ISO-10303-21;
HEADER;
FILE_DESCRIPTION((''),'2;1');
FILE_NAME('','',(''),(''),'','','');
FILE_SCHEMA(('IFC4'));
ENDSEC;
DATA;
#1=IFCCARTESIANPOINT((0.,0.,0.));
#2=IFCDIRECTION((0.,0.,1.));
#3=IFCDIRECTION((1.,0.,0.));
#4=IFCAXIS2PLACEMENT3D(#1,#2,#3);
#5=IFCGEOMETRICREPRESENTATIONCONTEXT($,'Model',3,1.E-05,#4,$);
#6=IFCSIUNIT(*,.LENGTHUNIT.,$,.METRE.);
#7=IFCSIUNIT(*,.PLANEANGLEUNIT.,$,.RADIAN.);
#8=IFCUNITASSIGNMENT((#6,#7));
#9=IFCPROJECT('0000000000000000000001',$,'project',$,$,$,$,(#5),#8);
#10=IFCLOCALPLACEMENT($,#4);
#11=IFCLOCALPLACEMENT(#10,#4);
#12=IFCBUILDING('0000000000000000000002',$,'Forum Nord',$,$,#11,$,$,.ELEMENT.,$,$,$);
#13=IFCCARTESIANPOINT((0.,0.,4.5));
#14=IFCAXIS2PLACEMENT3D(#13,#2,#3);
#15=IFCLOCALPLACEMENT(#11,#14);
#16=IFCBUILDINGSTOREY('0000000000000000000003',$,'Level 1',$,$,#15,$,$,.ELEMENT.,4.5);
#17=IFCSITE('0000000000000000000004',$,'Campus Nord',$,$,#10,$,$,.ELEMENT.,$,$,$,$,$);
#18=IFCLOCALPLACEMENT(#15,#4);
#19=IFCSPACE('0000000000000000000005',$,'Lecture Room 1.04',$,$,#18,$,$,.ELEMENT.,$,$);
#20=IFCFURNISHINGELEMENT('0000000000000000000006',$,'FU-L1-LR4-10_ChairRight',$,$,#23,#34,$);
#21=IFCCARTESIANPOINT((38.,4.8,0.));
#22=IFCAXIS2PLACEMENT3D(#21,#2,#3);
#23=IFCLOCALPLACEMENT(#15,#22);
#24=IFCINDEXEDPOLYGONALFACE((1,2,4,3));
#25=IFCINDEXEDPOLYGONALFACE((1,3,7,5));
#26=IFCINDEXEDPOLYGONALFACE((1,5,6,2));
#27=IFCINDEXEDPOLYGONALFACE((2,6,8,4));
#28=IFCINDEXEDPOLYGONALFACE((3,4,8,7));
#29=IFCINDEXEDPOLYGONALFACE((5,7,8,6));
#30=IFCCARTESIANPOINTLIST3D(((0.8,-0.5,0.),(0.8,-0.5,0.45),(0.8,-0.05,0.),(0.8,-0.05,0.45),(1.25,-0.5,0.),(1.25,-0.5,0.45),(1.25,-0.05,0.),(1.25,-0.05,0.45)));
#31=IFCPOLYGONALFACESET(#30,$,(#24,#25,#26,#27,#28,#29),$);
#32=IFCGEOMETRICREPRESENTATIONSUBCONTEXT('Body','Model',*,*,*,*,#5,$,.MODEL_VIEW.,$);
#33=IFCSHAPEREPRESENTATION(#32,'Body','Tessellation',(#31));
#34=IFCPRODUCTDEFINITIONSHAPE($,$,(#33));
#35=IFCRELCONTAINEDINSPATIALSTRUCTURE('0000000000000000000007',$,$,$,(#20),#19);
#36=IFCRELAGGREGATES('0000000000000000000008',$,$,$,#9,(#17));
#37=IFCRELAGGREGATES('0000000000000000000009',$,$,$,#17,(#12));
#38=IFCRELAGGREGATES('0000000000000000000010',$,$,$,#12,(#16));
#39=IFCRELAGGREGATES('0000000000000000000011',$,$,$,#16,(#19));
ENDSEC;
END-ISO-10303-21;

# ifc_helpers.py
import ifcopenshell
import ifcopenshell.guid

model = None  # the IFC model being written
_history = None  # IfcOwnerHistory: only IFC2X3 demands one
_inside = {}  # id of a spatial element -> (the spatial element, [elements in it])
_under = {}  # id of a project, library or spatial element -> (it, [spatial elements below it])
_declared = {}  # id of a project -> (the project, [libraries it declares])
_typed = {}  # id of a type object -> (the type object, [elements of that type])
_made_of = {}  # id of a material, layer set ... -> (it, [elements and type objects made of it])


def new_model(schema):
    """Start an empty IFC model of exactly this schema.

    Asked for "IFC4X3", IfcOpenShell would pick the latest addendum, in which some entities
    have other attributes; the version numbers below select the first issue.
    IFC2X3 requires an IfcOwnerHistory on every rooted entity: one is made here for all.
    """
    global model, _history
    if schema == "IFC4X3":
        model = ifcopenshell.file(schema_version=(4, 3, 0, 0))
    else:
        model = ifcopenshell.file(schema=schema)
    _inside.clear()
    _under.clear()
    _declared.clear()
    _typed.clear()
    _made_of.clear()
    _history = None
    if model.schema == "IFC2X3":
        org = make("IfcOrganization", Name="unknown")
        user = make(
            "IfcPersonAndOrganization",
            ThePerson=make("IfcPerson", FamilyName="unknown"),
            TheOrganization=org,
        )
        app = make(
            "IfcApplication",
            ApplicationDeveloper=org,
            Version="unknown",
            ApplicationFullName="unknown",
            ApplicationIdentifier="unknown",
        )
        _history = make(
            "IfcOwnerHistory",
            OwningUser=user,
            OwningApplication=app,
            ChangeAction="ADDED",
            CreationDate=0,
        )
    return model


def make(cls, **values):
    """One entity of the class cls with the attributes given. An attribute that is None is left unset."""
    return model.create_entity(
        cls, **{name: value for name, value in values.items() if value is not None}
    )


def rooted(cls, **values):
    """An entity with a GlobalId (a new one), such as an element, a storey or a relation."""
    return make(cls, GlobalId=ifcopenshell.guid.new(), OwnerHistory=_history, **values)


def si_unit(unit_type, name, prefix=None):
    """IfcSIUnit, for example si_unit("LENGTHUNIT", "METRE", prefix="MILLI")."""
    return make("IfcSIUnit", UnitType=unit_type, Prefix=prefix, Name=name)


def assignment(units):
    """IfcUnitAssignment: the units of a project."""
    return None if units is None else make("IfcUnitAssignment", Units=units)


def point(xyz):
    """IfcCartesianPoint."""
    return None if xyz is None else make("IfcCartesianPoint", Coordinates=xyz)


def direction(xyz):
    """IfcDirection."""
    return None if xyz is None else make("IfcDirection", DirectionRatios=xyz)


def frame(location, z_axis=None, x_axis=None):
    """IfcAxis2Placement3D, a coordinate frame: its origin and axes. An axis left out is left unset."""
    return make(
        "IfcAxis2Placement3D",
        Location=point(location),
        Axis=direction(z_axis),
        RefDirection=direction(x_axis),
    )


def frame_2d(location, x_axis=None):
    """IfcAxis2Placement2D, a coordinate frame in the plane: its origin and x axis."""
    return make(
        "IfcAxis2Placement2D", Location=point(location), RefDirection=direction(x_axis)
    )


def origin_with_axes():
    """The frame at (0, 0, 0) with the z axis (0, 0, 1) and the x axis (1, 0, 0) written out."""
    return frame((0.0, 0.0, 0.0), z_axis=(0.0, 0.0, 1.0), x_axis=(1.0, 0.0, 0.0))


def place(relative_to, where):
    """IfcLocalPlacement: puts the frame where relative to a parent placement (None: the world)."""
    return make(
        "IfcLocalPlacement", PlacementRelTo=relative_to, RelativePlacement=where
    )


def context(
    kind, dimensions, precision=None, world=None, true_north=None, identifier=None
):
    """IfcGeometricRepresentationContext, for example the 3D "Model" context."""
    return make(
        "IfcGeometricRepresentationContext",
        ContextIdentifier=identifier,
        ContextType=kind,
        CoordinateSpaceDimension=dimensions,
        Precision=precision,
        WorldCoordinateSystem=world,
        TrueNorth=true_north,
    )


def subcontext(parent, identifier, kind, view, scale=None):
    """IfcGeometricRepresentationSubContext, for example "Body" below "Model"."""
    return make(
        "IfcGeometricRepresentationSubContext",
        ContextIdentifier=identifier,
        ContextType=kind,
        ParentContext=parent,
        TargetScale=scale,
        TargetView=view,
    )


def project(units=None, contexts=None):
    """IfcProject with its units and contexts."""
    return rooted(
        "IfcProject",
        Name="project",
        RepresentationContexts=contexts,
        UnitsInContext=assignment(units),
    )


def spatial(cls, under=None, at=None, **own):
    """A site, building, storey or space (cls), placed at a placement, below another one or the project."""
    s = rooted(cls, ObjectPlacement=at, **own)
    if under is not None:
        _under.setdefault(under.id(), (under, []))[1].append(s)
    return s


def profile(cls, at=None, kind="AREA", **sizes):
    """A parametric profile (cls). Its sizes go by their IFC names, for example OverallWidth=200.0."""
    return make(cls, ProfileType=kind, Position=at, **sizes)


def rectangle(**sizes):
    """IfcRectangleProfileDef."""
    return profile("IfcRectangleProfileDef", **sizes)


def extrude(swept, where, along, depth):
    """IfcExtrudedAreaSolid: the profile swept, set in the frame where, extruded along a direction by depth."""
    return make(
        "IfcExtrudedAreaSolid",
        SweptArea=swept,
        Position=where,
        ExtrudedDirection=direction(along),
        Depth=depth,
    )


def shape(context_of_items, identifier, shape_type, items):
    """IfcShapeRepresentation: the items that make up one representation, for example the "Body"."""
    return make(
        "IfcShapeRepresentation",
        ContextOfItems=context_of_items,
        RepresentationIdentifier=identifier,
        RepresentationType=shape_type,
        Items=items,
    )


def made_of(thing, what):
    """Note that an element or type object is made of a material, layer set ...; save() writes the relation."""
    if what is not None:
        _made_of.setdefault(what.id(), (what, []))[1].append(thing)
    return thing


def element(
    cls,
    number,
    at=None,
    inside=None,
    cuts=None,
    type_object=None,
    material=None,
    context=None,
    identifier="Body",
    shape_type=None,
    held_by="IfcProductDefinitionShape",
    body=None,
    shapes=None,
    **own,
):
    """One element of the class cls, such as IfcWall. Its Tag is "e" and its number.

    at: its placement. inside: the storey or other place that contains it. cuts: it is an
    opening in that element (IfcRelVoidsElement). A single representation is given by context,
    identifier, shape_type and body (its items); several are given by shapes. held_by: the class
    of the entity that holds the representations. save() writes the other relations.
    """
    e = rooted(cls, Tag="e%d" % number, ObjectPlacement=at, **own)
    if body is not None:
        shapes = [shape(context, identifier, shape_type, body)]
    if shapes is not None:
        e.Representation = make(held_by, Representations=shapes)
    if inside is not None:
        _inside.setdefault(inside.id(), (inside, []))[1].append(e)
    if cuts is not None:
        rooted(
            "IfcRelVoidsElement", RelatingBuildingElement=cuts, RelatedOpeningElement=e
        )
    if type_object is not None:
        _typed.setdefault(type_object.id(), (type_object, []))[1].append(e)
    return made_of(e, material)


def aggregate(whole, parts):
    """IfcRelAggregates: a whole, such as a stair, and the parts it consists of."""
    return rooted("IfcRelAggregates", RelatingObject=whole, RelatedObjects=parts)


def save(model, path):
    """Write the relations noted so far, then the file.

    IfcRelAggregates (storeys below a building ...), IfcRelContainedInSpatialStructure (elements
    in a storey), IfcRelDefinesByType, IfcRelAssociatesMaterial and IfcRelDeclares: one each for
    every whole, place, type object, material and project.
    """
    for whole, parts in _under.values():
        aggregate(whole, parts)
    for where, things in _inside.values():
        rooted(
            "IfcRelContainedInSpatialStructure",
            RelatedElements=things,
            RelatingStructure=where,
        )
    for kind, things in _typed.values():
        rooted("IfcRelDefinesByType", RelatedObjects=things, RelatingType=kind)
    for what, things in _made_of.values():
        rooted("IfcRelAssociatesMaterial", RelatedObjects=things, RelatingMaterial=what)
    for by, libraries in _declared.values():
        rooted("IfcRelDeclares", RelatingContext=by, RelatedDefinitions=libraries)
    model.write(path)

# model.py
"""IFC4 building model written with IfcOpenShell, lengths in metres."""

from ifc_helpers import new_model, si_unit, frame, frame_2d, origin_with_axes, place, context, subcontext, project, spatial, rectangle, extrude, element, save


model = new_model("IFC4")

# Units and contexts
model_context = context("Model", 3, precision=1e-05, world=origin_with_axes())
body_context = subcontext(model_context, "Body", "Model", "MODEL_VIEW")
ifc_project = project(units=[si_unit("LENGTHUNIT", "METRE"), si_unit("PLANEANGLEUNIT", "RADIAN")], contexts=[model_context])

# Site, building, storey
site_placement = place(None, origin_with_axes())
site = spatial("IfcSite", under=ifc_project, at=site_placement, Name="Campus Nord", CompositionType="ELEMENT")
building_placement = place(site_placement, origin_with_axes())
building = spatial("IfcBuilding", under=site, at=building_placement, Name="Forum Nord", CompositionType="ELEMENT")
storey_placement = place(building_placement, frame((0.0, 0.0, 4.5), z_axis=(0.0, 0.0, 1.0), x_axis=(1.0, 0.0, 0.0)))
storey = spatial("IfcBuildingStorey", under=building, at=storey_placement, Name="Level 1", CompositionType="ELEMENT", Elevation=4.5)

# Shared definitions
space_placement = place(storey_placement, origin_with_axes())
space = spatial("IfcSpace", under=storey, at=space_placement, Name="Lecture Room 1.04", CompositionType="ELEMENT")

# Furnishing element
furnishing_1_placement = place(storey_placement, frame((38.0, 4.8, 0.0), z_axis=(0.0, 0.0, 1.0), x_axis=(1.0, 0.0, 0.0)))
element("IfcFurnishingElement", 1, at=furnishing_1_placement, inside=space, Name="FU-L1-LR4-10_ChairRight", context=body_context, shape_type="SweptSolid", body=[
    extrude(rectangle(XDim=0.45, YDim=0.45, at=frame_2d((1.025, -0.275), x_axis=(1.0, 0.0))), origin_with_axes(), (0.0, 0.0, 1.0), 0.45),
])

save(model, "model.ifc")
